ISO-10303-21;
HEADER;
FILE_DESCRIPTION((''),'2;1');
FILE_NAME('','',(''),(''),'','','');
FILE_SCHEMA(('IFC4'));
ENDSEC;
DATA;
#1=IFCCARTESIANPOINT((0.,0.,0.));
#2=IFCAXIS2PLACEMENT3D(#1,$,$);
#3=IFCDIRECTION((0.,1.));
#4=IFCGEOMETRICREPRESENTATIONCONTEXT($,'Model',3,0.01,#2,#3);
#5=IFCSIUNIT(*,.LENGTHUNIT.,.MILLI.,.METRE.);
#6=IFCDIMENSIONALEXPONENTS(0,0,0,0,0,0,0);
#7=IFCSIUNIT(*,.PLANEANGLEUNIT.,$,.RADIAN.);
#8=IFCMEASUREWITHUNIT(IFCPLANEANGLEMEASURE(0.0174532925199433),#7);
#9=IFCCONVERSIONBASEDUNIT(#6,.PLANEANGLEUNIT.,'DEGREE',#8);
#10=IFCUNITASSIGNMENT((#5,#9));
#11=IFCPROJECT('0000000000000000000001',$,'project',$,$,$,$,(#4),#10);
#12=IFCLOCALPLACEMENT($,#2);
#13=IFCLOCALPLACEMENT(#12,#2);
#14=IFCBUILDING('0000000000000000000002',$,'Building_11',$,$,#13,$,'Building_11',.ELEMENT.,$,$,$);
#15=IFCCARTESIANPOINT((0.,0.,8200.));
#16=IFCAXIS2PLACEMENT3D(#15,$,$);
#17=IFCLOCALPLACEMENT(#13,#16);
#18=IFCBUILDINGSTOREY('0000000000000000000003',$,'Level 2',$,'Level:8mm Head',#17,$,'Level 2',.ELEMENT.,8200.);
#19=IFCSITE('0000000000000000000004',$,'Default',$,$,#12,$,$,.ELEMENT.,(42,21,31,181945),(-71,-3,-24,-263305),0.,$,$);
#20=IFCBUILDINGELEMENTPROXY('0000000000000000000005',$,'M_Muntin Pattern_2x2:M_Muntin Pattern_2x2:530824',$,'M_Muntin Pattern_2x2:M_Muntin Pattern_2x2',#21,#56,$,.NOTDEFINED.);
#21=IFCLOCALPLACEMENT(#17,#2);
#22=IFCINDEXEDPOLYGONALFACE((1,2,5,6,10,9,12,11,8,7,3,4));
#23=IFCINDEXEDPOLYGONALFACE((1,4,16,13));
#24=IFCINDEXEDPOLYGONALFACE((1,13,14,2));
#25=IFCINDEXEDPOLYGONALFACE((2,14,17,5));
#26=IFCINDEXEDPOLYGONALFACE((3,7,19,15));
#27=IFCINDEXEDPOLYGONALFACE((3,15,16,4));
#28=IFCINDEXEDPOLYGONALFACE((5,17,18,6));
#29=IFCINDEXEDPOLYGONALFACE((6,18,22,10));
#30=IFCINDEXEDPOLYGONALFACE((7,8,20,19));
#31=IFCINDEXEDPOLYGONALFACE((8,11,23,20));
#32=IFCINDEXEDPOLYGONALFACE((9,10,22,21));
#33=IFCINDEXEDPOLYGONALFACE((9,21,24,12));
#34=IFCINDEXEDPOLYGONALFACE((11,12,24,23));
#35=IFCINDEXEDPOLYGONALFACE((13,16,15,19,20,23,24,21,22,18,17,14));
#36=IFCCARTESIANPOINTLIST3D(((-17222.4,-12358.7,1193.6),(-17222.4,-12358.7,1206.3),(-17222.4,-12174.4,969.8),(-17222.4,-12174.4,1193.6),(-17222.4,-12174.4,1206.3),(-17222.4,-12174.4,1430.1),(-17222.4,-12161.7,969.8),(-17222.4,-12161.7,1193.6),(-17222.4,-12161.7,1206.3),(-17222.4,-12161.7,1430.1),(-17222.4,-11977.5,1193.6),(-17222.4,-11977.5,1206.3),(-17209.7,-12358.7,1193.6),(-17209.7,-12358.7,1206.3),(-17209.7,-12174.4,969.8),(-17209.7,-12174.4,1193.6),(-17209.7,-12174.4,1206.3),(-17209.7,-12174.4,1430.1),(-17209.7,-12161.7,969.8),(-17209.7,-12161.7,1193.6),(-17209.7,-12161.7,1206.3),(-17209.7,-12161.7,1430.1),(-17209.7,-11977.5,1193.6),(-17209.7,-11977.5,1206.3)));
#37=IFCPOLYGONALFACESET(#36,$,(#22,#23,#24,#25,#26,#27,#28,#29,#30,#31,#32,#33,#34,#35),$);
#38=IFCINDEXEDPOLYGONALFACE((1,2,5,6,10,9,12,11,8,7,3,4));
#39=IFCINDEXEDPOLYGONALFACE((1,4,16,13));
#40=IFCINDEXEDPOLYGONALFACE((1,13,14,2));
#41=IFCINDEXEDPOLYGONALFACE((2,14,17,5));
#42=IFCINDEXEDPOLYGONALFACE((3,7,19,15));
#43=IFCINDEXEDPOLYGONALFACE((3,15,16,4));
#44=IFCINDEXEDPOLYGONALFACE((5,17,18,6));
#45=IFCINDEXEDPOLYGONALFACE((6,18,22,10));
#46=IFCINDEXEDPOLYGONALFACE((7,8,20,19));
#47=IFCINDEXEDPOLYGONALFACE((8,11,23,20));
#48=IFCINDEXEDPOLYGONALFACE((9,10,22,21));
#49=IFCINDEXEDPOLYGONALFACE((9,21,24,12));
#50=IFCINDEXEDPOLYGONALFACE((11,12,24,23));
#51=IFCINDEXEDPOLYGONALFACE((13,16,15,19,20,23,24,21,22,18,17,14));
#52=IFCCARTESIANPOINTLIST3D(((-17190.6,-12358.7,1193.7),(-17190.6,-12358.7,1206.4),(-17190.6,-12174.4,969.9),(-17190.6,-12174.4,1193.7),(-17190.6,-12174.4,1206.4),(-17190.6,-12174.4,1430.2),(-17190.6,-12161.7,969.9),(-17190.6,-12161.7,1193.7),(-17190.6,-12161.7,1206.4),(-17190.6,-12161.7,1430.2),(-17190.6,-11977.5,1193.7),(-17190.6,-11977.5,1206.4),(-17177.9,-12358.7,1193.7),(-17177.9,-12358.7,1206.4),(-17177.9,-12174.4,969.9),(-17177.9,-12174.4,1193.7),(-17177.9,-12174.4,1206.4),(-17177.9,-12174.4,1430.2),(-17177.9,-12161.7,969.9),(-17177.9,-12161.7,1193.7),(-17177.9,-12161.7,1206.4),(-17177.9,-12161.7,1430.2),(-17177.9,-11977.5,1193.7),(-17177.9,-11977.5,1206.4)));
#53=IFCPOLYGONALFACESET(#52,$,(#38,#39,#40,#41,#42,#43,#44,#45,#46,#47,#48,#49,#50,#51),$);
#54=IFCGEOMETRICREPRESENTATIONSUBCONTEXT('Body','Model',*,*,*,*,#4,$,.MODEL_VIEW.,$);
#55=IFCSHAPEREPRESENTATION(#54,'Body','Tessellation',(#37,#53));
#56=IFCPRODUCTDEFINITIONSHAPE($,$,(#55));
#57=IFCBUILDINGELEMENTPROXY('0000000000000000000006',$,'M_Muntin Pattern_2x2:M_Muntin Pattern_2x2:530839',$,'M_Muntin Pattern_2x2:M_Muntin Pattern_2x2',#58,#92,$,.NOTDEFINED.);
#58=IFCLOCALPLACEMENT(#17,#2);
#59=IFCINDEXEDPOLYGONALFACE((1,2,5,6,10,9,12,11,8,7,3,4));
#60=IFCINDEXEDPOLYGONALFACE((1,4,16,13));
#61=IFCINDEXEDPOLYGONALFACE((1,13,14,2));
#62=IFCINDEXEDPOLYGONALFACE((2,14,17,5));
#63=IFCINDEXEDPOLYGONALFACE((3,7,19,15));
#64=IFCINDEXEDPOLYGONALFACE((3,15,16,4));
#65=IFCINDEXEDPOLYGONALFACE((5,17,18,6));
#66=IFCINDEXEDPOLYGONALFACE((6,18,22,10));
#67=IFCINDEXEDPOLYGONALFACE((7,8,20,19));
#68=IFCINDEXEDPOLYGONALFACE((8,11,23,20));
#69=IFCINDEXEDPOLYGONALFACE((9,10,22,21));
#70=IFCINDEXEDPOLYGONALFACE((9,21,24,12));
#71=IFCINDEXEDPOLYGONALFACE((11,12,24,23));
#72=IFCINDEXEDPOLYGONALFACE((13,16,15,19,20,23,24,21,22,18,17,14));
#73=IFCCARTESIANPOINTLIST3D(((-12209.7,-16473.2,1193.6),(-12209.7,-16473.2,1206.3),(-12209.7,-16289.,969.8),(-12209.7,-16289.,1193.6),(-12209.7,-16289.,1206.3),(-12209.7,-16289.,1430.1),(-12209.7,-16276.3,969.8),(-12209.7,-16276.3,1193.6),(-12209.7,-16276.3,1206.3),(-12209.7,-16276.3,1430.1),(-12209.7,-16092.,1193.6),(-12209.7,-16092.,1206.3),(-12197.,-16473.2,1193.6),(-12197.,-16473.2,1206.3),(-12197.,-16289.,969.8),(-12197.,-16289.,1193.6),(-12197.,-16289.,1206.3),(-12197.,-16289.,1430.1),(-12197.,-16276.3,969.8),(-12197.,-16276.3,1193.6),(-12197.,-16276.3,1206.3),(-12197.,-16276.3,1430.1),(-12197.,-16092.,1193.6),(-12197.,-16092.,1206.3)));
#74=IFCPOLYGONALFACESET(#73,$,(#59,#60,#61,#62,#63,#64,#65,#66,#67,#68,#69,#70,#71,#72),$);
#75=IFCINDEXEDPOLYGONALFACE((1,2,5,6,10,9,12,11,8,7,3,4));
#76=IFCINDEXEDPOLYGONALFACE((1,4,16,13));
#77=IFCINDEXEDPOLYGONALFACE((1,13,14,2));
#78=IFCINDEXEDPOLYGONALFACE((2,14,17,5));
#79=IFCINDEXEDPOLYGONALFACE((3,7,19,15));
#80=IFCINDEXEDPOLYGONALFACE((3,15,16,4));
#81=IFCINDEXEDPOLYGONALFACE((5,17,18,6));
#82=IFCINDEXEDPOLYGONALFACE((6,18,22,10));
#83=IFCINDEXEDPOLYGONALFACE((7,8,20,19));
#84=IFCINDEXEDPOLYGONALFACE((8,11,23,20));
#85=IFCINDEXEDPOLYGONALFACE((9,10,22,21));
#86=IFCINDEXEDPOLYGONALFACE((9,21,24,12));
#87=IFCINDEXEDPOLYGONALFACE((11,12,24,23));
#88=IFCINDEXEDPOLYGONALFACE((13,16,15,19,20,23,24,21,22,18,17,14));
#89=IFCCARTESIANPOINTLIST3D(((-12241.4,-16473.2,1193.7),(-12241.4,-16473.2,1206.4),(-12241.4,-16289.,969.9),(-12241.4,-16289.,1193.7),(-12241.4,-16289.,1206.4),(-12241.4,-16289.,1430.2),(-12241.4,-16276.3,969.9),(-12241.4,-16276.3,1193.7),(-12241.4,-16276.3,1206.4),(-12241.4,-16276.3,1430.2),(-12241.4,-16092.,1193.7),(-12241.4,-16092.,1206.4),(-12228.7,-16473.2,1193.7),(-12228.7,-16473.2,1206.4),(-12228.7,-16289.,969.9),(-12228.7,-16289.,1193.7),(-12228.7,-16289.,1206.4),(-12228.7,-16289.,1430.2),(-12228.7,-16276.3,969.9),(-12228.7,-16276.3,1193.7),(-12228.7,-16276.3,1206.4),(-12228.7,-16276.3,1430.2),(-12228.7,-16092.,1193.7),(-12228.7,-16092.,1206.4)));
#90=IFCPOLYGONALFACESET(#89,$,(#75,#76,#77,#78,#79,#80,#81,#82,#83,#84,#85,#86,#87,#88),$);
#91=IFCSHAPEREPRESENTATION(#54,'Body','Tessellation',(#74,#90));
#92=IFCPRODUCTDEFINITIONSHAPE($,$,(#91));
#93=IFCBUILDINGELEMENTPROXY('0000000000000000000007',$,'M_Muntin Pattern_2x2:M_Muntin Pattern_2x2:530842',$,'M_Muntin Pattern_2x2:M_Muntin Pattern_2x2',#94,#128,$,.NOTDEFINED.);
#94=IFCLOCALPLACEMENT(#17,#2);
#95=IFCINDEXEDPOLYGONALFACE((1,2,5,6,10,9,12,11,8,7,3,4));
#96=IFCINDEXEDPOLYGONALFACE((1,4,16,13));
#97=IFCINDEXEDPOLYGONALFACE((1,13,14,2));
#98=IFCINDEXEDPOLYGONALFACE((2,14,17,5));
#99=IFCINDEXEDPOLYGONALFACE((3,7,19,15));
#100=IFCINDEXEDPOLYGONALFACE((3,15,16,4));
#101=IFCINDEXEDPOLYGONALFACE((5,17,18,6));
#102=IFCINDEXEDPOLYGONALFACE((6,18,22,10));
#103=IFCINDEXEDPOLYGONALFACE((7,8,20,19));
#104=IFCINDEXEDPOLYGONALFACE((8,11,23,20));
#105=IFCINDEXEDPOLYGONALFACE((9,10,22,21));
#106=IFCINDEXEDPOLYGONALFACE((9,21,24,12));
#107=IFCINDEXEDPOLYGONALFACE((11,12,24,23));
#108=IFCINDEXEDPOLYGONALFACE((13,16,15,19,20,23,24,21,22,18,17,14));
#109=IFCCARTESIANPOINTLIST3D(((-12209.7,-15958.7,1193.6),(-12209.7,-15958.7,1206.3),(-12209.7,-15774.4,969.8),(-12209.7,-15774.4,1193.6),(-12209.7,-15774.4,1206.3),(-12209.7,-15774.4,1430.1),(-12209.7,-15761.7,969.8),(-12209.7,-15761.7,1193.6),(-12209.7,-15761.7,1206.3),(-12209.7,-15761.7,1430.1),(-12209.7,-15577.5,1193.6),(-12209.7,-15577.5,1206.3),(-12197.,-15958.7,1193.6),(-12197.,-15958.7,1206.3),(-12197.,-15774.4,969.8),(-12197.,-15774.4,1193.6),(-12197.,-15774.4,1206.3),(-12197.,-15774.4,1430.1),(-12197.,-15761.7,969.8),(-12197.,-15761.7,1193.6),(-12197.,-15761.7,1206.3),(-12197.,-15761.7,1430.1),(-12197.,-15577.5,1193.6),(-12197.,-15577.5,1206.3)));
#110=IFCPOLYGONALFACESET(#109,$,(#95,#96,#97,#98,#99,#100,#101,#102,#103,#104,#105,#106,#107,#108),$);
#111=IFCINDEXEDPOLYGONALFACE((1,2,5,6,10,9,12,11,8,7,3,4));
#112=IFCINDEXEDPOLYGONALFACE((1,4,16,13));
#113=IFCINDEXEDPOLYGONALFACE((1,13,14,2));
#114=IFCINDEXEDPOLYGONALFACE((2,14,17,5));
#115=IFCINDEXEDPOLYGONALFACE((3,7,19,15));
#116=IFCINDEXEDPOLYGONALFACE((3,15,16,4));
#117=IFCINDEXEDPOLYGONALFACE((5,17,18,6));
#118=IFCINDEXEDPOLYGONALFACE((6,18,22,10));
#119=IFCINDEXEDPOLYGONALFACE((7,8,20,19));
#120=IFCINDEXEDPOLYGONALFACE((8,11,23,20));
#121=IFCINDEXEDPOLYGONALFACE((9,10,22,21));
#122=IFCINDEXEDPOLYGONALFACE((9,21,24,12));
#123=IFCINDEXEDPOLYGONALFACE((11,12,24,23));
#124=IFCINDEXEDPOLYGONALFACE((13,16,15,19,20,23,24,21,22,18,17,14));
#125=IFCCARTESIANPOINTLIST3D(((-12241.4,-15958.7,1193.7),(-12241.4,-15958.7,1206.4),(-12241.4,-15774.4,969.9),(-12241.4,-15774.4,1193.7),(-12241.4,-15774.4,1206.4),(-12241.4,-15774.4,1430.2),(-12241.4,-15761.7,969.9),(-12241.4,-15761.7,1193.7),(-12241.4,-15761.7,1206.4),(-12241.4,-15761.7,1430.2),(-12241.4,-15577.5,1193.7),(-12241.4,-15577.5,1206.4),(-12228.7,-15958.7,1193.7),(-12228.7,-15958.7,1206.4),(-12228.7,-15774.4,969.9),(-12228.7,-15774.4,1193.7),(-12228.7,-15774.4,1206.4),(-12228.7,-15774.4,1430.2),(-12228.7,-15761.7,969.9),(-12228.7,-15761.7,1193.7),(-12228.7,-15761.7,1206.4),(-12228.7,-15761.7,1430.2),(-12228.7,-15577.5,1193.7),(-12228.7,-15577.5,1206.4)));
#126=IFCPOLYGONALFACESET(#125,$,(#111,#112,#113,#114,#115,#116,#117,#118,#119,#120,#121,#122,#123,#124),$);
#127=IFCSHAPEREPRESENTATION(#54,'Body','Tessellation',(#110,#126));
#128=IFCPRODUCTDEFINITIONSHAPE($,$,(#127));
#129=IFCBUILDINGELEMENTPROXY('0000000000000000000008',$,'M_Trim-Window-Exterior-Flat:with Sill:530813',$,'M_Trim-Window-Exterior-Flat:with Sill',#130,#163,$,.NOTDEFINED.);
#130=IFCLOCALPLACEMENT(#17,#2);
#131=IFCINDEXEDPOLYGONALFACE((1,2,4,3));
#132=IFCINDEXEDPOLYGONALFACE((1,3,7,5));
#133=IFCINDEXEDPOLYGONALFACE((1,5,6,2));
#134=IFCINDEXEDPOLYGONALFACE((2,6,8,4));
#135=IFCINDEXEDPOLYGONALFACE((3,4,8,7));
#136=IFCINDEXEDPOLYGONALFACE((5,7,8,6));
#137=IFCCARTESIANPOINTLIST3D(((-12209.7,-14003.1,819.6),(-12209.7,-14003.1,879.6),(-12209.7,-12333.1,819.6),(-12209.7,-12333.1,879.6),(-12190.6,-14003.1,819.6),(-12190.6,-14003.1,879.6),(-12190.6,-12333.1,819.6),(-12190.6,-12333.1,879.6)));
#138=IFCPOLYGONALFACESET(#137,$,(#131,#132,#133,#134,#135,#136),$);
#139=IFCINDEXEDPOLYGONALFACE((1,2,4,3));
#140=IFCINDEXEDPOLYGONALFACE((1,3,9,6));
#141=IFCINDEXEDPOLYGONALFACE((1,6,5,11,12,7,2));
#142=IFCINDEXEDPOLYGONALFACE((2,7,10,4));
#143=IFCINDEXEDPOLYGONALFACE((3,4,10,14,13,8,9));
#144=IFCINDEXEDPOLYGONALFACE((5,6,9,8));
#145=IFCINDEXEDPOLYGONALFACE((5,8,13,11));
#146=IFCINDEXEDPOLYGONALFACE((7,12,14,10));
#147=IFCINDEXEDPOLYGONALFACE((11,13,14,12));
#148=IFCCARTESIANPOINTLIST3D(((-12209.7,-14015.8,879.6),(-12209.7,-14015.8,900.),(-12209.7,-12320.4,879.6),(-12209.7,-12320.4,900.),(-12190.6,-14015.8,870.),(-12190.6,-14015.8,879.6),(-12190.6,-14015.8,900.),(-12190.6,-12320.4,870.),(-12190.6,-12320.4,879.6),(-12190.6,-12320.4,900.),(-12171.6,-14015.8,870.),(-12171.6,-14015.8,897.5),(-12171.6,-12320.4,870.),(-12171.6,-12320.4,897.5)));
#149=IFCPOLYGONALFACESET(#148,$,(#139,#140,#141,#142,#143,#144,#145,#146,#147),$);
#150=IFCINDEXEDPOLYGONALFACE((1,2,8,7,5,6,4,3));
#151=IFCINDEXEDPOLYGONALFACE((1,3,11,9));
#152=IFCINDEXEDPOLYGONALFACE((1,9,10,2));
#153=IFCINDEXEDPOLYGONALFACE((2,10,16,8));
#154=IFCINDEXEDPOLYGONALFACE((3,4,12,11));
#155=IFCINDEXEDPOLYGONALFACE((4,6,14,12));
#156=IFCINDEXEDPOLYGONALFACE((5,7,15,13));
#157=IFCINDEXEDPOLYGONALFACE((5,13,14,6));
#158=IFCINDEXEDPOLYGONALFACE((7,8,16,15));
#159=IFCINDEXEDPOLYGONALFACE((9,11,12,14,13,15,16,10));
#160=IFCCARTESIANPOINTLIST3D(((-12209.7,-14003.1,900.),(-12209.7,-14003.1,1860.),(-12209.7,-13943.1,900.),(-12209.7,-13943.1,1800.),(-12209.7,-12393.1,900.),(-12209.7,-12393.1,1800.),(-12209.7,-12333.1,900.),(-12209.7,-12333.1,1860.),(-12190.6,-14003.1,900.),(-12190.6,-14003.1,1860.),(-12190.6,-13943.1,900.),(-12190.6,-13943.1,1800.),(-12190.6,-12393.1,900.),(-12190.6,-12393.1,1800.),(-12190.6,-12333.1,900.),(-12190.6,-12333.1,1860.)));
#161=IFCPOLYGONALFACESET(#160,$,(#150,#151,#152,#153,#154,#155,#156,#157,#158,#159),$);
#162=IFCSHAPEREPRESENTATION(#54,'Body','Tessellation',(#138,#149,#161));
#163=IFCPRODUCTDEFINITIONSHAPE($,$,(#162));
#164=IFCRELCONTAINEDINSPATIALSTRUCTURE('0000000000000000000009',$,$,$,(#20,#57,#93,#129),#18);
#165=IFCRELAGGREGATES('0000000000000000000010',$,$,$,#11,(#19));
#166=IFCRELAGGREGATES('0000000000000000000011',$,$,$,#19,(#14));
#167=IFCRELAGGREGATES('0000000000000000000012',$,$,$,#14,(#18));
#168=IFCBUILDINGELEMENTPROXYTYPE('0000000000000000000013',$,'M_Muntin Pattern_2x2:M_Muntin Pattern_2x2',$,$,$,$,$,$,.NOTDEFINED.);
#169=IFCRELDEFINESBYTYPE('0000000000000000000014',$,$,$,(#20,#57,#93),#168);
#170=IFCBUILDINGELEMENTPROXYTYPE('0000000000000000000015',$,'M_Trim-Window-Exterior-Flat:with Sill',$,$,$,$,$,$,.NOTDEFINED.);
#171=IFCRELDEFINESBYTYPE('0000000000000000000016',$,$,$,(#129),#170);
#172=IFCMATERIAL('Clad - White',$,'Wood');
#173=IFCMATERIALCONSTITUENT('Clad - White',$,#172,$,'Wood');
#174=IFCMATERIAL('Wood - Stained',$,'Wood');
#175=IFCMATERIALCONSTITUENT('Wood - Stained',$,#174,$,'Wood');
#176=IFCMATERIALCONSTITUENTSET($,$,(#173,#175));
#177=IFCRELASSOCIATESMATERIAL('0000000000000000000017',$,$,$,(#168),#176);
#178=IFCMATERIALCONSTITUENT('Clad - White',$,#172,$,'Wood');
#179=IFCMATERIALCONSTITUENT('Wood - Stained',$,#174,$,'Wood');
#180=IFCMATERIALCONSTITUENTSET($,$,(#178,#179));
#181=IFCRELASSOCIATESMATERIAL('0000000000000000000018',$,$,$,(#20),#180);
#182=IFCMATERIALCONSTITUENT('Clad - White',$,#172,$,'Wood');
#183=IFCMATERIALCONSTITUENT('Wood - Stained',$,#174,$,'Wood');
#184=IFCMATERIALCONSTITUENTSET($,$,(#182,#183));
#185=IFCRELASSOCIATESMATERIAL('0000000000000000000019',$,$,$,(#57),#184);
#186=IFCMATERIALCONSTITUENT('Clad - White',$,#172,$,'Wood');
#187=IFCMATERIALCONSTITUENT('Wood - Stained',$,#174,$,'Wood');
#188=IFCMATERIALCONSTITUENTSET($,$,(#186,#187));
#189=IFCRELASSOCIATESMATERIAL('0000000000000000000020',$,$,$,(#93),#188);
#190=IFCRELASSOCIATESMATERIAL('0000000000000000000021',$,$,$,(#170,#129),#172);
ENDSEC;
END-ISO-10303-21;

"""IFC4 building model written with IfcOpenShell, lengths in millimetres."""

from ifc_helpers import new_model, entity, si_unit, converted_unit, direction, frame, origin, place, context, subcontext, project, spatial, indexed_curve, outline, extrude, source, transform, mapped, material, constituent, constituent_set, type_object, type_shapes, element, save


model = new_model("IFC4")

# Units and contexts
model_context = context("Model", 3, precision=0.01, world=origin(), true_north=direction((0.0, 1.0)))
body_context = subcontext(model_context, "Body", "Model", "MODEL_VIEW")
ifc_project = project(units=[si_unit("LENGTHUNIT", "METRE", prefix="MILLI"), converted_unit("PLANEANGLEUNIT", "DEGREE", entity("IfcPlaneAngleMeasure", 0.0174532925199433), si_unit("PLANEANGLEUNIT", "RADIAN"), dimensions=[0, 0, 0, 0, 0, 0, 0])], contexts=[model_context])

# Site, building, storey
site_placement = place(None, origin())
site = spatial("IfcSite", under=ifc_project, at=site_placement, Name="Default", CompositionType="ELEMENT", RefLatitude=(42, 21, 31, 181945), RefLongitude=(-71, -3, -24, -263305), RefElevation=0.0)
building_placement = place(site_placement, origin())
building = spatial("IfcBuilding", under=site, at=building_placement, Name="Building_11", LongName="Building_11", CompositionType="ELEMENT")
storey_placement = place(building_placement, frame((0.0, 0.0, 8200.0)))
storey = spatial("IfcBuildingStorey", under=building, at=storey_placement, Name="Level 2", ObjectType="Level:8mm Head", LongName="Level 2", CompositionType="ELEMENT", Elevation=8200.0)

# Building element proxies
ifc_material_1 = material(Name="Clad - White", Category="Wood")
ifc_material_2 = material(Name="Wood - Stained", Category="Wood")
ifc_constituent_1 = constituent(ifc_material_1, Name="Clad - White", Category="Wood")
ifc_constituent_2 = constituent(ifc_material_2, Name="Wood - Stained", Category="Wood")
ifc_constituent_set_1 = constituent_set(constituents=[ifc_constituent_1, ifc_constituent_2])
building_element_proxy_type_1 = type_object("IfcBuildingElementProxyType", Name="M_Muntin Pattern_2x2:M_Muntin Pattern_2x2", PredefinedType="NOTDEFINED", material=ifc_constituent_set_1)
shared_shape_1 = source(origin(), body_context, "Body", "SweptSolid", [
    extrude(outline(indexed_curve([(6.4, -6.4), (230.1, -6.4), (230.1, 6.3), (6.4, 6.3), (6.4, 190.6), (-6.3, 190.6), (-6.3, 6.3), (-230.2, 6.3), (-230.2, -6.4), (-6.3, -6.4), (-6.3, -190.6), (6.4, -190.6), (6.4, -6.4)], self_intersect=False)), frame((0.0, -22.2, 230.1), z_axis=(0.0, 1.0, 0.0), x_axis=(0.0, 0.0, 1.0)), (0.0, 0.0, 1.0), 12.7),
    extrude(outline(indexed_curve([(6.4, -6.4), (230.2, -6.4), (230.2, 6.3), (6.4, 6.3), (6.4, 190.6), (-6.3, 190.6), (-6.3, 6.3), (-230.2, 6.3), (-230.2, -6.4), (-6.3, -6.4), (-6.3, -190.6), (6.4, -190.6), (6.4, -6.4)], self_intersect=False)), frame((0.0, 9.5, 230.2), z_axis=(0.0, 1.0, 0.0), x_axis=(0.0, 0.0, 1.0)), (0.0, 0.0, 1.0), 12.7),
])
type_shapes(building_element_proxy_type_1, [shared_shape_1])
ifc_constituent_3 = constituent(ifc_material_1, Name="Clad - White", Category="Wood")
ifc_constituent_4 = constituent(ifc_material_2, Name="Wood - Stained", Category="Wood")
ifc_constituent_set_2 = constituent_set(constituents=[ifc_constituent_3, ifc_constituent_4])
proxy_1_placement = place(storey_placement, frame((-17200.2, -12168.1, 969.9), z_axis=(0.0, 0.0, 1.0), x_axis=(0.0, -1.0, 0.0)))
element("IfcBuildingElementProxy", 1, at=proxy_1_placement, inside=storey, type_object=building_element_proxy_type_1, material=ifc_constituent_set_2, Name="M_Muntin Pattern_2x2:M_Muntin Pattern_2x2:530824", ObjectType="M_Muntin Pattern_2x2:M_Muntin Pattern_2x2", PredefinedType="NOTDEFINED", context=body_context, shape_type="MappedRepresentation", body=[
    mapped(shared_shape_1, transform((0.0, 0.0, 0.0), scale=1.0)),
])
ifc_constituent_5 = constituent(ifc_material_1, Name="Clad - White", Category="Wood")
ifc_constituent_6 = constituent(ifc_material_2, Name="Wood - Stained", Category="Wood")
ifc_constituent_set_3 = constituent_set(constituents=[ifc_constituent_5, ifc_constituent_6])
proxy_2_placement = place(storey_placement, frame((-12219.2, -16282.6, 969.9), z_axis=(0.0, 0.0, 1.0), x_axis=(0.0, 1.0, 0.0)))
element("IfcBuildingElementProxy", 2, at=proxy_2_placement, inside=storey, type_object=building_element_proxy_type_1, material=ifc_constituent_set_3, Name="M_Muntin Pattern_2x2:M_Muntin Pattern_2x2:530839", ObjectType="M_Muntin Pattern_2x2:M_Muntin Pattern_2x2", PredefinedType="NOTDEFINED", context=body_context, shape_type="MappedRepresentation", body=[
    mapped(shared_shape_1, transform((0.0, 0.0, 0.0), scale=1.0)),
])
ifc_constituent_7 = constituent(ifc_material_1, Name="Clad - White", Category="Wood")
ifc_constituent_8 = constituent(ifc_material_2, Name="Wood - Stained", Category="Wood")
ifc_constituent_set_4 = constituent_set(constituents=[ifc_constituent_7, ifc_constituent_8])
proxy_3_placement = place(storey_placement, frame((-12219.2, -15768.1, 969.9), z_axis=(0.0, 0.0, 1.0), x_axis=(0.0, 1.0, 0.0)))
element("IfcBuildingElementProxy", 3, at=proxy_3_placement, inside=storey, type_object=building_element_proxy_type_1, material=ifc_constituent_set_4, Name="M_Muntin Pattern_2x2:M_Muntin Pattern_2x2:530842", ObjectType="M_Muntin Pattern_2x2:M_Muntin Pattern_2x2", PredefinedType="NOTDEFINED", context=body_context, shape_type="MappedRepresentation", body=[
    mapped(shared_shape_1, transform((0.0, 0.0, 0.0), scale=1.0)),
])
building_element_proxy_type_2 = type_object("IfcBuildingElementProxyType", Name="M_Trim-Window-Exterior-Flat:with Sill", PredefinedType="NOTDEFINED", material=ifc_material_1)
shared_shape_2 = source(origin(), body_context, "Body", "SweptSolid", [
    extrude(outline(indexed_curve([(-835.0, -30.0), (835.0, -30.0), (835.0, 30.0), (-835.0, 30.0), (-835.0, -30.0)], self_intersect=False)), frame((0.0, -950.4, 0.0), z_axis=(0.0, 0.0, 1.0), x_axis=(-1.0, 0.0, 0.0)), (0.0, 0.0, 1.0), 19.1),
    extrude(outline(indexed_curve([(-19.0, -15.2), (0.0, -15.2), (0.0, -5.7), (19.0, -5.7), (19.0, 14.8), (0.0, 14.8), (-19.0, 12.3), (-19.0, -15.2)], self_intersect=False)), frame((-847.7, -914.8, 19.0), z_axis=(1.0, 0.0, 0.0), x_axis=(0.0, 0.0, -1.0)), (0.0, 0.0, 1.0), 1695.4),
    extrude(outline(indexed_curve([(-495.0, -835.0), (465.0, -835.0), (465.0, -775.0), (-435.0, -775.0), (-435.0, 775.0), (465.0, 775.0), (465.0, 835.0), (-495.0, 835.0), (-495.0, -835.0)], self_intersect=False)), frame((0.0, -435.0, 0.0), z_axis=(0.0, 0.0, 1.0), x_axis=(0.0, -1.0, 0.0)), (0.0, 0.0, 1.0), 19.1),
])
type_shapes(building_element_proxy_type_2, [shared_shape_2])
for number, where, z_axis, x_axis, name in (
    (4, (-12209.7, -13168.1, 1800.0), (1.0, 0.0, 0.0), (0.0, 1.0, 0.0), "M_Trim-Window-Exterior-Flat:with Sill:530813"),
):
    element("IfcBuildingElementProxy", number, at=place(storey_placement, frame(where, z_axis=z_axis, x_axis=x_axis)), inside=storey, type_object=building_element_proxy_type_2, material=ifc_material_1, Name=name, ObjectType="M_Trim-Window-Exterior-Flat:with Sill", PredefinedType="NOTDEFINED", context=body_context, shape_type="MappedRepresentation", body=[
        mapped(shared_shape_2, transform((0.0, 0.0, 0.0), scale=1.0)),
    ])

save(model, "model.ifc")
